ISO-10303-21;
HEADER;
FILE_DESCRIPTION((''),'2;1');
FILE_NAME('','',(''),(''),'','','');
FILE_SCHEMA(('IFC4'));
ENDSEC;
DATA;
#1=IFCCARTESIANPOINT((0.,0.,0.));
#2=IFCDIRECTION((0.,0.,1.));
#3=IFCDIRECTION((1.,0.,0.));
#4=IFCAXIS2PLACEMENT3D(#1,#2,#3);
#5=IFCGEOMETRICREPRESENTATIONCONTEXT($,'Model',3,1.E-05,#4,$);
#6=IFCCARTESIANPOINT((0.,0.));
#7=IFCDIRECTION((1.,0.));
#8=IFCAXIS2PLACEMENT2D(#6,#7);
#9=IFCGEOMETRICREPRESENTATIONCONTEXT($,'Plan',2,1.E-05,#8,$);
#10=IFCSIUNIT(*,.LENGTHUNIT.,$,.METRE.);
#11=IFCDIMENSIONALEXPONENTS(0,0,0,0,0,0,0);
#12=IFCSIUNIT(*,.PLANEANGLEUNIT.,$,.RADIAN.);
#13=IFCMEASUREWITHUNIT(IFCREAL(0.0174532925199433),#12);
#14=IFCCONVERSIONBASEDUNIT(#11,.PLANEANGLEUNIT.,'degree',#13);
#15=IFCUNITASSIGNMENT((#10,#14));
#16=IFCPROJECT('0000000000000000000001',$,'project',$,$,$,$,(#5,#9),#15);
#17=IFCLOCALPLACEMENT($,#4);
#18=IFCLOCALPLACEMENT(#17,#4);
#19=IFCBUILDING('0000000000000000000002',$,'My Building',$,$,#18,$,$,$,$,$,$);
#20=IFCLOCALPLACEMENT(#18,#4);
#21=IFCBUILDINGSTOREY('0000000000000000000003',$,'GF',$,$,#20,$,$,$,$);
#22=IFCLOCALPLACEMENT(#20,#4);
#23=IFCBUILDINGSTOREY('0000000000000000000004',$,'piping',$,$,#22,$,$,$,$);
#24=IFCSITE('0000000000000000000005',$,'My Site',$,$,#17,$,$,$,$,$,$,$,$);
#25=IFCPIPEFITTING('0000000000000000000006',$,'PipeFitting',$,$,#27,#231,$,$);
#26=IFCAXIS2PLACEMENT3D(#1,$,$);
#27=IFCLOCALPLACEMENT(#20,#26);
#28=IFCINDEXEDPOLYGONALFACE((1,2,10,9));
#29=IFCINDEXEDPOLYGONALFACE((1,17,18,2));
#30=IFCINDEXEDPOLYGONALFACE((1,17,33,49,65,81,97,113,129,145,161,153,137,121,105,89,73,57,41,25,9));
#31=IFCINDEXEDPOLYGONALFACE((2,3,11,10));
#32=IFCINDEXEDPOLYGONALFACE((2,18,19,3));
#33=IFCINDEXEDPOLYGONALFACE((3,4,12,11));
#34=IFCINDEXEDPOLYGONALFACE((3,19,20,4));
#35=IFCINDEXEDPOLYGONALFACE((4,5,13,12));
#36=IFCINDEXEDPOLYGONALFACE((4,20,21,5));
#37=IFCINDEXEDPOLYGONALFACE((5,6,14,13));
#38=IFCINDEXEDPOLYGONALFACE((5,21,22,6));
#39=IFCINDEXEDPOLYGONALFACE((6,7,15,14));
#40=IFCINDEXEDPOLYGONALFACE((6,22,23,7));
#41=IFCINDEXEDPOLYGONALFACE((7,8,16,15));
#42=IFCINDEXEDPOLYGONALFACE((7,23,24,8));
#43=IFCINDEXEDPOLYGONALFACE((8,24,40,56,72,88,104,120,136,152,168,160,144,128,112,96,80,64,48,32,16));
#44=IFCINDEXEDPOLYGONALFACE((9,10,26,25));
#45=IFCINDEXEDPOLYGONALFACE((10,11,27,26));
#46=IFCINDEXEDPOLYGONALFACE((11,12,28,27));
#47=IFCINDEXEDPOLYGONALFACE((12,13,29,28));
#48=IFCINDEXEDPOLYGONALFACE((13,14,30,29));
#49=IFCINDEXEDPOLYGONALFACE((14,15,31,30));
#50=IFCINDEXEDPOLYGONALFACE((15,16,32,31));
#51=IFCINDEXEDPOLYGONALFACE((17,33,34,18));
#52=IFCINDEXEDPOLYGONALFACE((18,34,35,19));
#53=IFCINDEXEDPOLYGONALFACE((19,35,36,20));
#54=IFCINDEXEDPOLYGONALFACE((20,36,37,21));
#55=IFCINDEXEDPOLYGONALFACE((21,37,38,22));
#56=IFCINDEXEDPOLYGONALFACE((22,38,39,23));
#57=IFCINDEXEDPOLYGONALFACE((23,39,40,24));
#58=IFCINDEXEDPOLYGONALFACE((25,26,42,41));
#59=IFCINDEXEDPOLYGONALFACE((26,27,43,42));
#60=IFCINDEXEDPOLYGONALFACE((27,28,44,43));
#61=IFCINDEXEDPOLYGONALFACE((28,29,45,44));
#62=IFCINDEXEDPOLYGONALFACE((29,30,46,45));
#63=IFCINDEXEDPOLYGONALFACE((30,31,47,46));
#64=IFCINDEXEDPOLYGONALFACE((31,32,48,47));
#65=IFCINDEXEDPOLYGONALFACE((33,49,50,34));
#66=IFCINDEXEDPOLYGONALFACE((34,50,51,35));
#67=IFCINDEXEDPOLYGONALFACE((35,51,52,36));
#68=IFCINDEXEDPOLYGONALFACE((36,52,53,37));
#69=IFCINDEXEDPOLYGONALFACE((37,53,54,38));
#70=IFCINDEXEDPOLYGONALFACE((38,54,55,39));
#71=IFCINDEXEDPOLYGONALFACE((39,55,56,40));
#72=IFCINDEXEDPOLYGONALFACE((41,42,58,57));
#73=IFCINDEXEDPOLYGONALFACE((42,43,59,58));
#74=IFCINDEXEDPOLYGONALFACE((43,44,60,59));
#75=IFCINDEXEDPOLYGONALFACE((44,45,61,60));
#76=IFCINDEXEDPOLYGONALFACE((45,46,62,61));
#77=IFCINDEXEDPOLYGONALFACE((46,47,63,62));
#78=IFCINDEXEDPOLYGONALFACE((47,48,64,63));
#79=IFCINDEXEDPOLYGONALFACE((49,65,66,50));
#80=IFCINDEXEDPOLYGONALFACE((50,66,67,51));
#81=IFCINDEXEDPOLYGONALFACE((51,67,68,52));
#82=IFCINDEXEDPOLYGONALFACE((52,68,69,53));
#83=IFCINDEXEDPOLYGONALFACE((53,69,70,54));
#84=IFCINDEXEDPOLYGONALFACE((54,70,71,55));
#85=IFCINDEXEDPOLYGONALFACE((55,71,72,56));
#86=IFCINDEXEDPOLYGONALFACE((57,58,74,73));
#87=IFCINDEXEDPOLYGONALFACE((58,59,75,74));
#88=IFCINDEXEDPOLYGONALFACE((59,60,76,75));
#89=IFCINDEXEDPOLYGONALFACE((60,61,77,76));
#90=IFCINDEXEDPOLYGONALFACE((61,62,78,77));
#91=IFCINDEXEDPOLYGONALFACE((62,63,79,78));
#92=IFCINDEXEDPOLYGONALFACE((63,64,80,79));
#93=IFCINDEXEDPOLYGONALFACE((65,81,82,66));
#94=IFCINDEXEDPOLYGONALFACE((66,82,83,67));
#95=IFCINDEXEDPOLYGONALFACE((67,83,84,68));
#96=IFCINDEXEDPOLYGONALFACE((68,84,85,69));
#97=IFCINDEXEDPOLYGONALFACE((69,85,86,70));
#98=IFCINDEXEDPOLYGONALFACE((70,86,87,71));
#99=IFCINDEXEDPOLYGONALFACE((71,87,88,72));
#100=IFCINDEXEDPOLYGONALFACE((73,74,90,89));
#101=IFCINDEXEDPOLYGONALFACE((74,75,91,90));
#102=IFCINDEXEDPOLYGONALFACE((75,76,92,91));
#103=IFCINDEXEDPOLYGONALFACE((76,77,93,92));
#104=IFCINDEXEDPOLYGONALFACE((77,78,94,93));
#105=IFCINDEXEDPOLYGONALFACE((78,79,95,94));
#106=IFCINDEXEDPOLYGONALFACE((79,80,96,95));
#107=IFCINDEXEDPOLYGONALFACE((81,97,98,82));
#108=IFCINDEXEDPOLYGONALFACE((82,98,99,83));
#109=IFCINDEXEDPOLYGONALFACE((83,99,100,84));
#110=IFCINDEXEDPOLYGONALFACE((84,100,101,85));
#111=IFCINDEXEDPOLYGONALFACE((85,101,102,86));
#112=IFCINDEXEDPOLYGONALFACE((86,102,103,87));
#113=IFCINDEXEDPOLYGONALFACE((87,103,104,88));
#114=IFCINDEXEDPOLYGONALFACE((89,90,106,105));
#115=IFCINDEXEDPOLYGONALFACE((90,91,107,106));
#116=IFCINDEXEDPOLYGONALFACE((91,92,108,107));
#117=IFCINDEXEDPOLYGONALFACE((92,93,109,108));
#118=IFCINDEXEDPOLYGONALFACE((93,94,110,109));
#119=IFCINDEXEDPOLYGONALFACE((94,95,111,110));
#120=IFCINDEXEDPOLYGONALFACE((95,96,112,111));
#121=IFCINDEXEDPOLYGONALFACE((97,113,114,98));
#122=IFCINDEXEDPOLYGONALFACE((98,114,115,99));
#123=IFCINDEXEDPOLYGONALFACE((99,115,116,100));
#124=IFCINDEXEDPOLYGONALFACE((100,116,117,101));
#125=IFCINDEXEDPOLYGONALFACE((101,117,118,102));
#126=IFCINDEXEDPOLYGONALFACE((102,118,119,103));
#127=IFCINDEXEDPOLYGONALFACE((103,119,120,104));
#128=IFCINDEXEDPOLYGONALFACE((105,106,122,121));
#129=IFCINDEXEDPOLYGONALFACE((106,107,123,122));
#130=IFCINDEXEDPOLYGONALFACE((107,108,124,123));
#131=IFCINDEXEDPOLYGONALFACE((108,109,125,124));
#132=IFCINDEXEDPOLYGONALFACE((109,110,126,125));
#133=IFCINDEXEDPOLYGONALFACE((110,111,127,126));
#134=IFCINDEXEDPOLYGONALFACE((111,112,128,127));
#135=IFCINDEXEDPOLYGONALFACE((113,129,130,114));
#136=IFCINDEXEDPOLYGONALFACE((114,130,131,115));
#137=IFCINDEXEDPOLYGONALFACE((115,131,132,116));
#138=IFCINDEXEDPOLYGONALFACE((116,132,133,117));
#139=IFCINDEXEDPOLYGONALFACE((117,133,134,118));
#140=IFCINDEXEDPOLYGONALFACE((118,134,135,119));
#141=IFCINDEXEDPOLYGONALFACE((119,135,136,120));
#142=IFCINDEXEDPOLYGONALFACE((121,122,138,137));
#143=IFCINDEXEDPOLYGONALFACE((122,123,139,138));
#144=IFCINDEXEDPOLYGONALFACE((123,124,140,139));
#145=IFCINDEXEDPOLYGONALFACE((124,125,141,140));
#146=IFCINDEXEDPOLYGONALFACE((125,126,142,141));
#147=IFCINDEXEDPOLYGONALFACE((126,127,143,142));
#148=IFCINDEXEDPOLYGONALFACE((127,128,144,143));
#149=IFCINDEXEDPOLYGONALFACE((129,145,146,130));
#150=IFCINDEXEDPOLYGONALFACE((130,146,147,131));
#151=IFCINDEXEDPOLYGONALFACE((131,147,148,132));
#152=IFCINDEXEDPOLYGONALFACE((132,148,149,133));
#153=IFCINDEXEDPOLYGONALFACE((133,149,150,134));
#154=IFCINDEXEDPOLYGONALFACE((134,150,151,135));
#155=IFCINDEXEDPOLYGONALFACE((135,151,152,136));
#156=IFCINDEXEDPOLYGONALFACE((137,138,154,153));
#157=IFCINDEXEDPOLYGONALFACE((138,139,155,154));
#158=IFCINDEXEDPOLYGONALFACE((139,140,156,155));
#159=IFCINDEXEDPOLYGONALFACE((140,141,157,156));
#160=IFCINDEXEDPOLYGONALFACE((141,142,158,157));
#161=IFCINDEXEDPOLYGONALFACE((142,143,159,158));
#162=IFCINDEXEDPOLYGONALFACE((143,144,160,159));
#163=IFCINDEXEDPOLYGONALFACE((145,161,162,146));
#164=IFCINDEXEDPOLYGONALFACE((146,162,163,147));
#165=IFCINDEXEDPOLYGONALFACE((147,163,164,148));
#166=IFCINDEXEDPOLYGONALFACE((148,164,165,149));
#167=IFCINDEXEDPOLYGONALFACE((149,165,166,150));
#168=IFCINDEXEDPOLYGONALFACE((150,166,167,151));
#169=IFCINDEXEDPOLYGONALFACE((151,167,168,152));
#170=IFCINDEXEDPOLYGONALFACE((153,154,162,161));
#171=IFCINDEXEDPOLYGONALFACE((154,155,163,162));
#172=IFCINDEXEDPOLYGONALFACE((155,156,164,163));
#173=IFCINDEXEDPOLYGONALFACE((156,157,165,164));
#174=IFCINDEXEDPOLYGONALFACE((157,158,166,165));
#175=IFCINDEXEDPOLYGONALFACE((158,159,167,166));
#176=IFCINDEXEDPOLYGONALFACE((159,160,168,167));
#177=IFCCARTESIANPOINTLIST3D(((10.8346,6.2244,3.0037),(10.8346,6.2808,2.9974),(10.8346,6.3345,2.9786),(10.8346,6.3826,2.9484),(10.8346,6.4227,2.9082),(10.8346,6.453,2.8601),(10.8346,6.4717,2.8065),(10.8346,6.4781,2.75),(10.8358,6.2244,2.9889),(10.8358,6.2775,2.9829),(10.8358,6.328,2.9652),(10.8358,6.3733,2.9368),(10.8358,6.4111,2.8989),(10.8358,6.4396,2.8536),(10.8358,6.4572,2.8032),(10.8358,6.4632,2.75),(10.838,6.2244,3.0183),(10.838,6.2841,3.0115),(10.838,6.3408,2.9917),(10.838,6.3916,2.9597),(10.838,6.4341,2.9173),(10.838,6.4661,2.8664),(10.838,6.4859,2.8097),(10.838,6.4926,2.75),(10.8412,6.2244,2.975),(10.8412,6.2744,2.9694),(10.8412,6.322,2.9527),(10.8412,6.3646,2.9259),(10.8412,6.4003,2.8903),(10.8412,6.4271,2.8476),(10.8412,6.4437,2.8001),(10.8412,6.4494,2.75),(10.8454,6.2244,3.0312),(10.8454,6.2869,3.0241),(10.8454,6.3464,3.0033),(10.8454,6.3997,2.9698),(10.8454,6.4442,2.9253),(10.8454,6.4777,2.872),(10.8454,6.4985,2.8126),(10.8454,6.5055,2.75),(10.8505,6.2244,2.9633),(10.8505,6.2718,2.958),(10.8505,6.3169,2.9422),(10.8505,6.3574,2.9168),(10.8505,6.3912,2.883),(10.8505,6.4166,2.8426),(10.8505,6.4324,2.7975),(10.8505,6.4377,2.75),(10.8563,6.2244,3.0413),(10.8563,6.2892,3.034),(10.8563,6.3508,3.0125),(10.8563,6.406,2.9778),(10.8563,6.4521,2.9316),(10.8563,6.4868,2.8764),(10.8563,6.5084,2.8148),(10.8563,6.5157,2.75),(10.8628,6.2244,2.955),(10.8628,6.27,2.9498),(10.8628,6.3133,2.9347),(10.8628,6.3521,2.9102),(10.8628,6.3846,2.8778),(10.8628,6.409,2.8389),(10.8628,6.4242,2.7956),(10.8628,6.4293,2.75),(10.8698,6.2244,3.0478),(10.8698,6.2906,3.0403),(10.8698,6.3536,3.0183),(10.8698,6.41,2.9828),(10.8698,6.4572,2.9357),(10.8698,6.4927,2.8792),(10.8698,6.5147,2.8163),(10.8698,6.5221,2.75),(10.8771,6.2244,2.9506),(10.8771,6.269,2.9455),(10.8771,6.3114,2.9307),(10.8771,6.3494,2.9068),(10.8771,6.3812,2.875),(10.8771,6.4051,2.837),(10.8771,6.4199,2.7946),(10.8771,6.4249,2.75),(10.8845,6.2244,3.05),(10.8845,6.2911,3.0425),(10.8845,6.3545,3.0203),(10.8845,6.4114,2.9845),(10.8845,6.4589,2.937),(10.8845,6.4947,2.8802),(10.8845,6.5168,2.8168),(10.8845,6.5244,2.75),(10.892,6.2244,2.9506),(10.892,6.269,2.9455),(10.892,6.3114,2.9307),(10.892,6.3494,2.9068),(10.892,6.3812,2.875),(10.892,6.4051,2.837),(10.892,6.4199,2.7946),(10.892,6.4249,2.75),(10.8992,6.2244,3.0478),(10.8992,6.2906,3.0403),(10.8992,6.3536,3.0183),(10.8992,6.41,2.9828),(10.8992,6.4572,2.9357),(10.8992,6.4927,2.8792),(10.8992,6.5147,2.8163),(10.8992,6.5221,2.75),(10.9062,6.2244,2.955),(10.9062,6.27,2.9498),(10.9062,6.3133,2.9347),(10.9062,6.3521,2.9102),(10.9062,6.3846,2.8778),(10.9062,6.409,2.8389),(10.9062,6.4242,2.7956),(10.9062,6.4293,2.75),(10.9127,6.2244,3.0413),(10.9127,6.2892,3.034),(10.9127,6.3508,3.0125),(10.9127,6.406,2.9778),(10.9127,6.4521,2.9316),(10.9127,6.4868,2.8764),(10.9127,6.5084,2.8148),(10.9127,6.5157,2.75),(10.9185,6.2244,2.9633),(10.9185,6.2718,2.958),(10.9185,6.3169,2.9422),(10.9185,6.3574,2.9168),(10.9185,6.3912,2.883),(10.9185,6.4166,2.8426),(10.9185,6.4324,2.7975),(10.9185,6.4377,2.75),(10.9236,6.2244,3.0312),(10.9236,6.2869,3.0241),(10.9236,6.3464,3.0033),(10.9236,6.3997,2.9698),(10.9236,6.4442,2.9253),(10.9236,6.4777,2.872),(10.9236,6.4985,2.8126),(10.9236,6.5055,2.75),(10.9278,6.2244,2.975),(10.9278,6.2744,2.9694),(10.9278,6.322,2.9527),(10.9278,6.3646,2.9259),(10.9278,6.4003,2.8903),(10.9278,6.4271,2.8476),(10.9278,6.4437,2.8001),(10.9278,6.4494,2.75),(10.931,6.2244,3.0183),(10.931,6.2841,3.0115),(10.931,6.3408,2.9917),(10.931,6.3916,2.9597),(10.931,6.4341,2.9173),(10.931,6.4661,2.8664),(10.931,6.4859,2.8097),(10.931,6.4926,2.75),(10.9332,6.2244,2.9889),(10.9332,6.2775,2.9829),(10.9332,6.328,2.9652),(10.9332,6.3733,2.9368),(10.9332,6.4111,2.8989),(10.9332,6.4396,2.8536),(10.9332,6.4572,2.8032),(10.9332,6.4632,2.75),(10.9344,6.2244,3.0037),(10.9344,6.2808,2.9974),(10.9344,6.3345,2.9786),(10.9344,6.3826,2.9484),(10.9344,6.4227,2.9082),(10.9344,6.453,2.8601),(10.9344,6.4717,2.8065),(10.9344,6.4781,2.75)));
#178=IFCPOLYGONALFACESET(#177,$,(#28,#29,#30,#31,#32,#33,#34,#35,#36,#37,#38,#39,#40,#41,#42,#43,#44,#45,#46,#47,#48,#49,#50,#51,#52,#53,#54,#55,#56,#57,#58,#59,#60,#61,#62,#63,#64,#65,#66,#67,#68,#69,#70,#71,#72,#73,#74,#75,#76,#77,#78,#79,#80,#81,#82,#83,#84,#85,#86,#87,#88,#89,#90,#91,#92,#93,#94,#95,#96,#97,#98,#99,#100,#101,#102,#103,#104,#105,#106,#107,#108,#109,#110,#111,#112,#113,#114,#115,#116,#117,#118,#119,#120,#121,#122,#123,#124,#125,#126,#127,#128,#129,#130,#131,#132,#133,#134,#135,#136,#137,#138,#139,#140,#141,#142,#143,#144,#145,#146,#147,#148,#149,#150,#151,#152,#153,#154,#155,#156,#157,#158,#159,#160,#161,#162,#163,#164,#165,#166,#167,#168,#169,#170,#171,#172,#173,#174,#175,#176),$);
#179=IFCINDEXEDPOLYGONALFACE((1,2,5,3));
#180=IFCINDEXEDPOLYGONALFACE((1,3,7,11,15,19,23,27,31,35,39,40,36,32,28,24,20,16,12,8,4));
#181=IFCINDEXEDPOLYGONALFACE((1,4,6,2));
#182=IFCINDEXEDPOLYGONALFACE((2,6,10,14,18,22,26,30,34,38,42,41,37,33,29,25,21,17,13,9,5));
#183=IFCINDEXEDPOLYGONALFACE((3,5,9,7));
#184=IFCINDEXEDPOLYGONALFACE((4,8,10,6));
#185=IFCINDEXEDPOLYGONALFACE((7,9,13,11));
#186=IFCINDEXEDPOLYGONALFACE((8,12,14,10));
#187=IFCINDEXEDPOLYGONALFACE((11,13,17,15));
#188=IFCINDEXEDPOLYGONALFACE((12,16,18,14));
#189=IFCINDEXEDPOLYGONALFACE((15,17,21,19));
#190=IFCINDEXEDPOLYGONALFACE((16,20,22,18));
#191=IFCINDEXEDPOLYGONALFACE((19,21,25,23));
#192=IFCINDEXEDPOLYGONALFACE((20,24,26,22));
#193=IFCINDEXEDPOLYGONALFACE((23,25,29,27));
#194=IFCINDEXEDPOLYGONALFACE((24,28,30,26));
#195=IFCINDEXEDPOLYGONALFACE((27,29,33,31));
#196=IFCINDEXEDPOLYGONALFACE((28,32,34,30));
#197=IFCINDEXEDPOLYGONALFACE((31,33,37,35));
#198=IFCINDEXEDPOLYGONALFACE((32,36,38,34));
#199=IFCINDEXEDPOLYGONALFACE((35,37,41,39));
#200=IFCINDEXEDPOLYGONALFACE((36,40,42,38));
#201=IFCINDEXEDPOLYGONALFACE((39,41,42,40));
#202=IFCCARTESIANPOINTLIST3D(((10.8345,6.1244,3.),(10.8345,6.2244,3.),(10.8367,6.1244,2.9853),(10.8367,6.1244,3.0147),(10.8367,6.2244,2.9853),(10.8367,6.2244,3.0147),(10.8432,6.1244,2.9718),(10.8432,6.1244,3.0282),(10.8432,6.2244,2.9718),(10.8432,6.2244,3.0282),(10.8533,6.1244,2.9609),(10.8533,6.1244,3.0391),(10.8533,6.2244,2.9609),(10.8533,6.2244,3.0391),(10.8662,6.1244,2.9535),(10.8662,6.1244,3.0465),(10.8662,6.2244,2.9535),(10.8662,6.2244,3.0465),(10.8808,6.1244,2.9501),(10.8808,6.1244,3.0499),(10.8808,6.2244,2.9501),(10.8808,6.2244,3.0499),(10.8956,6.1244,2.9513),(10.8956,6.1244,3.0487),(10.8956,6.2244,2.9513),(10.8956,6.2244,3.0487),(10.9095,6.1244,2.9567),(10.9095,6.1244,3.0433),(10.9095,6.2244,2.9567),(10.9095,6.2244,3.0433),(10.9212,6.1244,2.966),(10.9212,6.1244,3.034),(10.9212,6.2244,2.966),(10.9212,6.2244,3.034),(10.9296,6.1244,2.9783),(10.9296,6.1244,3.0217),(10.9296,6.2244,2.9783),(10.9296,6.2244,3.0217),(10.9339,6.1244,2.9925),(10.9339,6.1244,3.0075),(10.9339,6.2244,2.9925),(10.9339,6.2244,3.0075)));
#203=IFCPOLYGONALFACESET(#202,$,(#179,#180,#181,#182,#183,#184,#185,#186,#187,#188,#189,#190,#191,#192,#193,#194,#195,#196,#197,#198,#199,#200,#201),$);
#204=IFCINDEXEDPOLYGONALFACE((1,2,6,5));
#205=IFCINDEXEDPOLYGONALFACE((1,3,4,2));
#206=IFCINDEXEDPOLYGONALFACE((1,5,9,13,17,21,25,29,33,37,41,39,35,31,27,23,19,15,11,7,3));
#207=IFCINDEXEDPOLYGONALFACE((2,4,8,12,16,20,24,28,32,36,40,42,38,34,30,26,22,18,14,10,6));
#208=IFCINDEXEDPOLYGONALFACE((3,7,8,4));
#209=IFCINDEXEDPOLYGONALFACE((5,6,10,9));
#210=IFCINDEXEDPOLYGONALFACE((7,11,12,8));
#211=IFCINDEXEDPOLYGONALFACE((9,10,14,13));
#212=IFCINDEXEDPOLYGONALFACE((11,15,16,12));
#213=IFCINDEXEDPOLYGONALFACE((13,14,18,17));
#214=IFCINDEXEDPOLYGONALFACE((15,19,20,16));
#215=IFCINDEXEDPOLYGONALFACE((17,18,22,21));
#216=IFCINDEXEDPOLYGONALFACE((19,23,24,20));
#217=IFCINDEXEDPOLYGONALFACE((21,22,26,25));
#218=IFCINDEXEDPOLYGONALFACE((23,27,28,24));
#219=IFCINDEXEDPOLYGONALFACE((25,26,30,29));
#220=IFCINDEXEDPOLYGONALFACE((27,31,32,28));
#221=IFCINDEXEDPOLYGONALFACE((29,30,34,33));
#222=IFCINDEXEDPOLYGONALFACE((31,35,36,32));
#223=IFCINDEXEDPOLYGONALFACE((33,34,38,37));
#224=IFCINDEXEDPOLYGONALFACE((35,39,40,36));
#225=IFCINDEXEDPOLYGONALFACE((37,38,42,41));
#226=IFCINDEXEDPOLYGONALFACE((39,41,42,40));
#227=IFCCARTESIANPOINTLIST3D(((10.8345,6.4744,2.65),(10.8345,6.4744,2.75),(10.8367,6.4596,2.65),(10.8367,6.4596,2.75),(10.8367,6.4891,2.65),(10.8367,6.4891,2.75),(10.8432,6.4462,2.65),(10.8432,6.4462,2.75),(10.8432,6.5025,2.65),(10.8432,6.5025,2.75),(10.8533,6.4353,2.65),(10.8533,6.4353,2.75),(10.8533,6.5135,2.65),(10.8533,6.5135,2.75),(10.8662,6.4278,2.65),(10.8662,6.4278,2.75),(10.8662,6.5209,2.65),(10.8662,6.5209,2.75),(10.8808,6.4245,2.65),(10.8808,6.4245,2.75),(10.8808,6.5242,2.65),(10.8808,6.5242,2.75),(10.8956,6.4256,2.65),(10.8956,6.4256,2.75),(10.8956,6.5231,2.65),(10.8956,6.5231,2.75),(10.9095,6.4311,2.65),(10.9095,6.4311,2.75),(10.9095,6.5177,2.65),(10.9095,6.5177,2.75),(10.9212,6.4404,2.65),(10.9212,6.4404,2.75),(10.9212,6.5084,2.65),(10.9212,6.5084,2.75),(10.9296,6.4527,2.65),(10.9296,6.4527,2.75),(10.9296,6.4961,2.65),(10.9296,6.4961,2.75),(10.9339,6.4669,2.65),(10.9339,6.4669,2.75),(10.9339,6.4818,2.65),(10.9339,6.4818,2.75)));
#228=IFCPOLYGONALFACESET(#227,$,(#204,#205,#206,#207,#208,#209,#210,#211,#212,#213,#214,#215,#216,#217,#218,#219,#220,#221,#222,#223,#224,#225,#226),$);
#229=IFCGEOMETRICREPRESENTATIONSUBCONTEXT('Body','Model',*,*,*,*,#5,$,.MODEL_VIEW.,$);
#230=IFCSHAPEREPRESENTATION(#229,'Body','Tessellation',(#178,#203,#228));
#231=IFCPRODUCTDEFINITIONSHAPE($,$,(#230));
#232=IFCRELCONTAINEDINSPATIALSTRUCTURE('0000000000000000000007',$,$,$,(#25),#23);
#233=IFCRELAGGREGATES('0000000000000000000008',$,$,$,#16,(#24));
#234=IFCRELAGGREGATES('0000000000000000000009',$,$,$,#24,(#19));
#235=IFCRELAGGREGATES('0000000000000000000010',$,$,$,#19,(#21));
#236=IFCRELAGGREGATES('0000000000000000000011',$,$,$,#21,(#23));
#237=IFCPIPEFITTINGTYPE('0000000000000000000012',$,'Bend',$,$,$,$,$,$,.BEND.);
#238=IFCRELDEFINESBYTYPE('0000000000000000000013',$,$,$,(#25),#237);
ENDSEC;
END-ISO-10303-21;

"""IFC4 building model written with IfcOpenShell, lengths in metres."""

from ifc_helpers import new_model, entity, si_unit, converted_unit, frame, origin_with_axes, origin_2d_with_axis, place, context, subcontext, project, spatial, circle, extrude, source, transform, mapped, type_object, type_shapes, element, save


model = new_model("IFC4")

# Units and contexts
model_context = context("Model", 3, precision=1e-05, world=origin_with_axes())
plan_context = context("Plan", 2, precision=1e-05, world=origin_2d_with_axis())
body_context = subcontext(model_context, "Body", "Model", "MODEL_VIEW")
ifc_project = project(units=[si_unit("LENGTHUNIT", "METRE"), converted_unit("PLANEANGLEUNIT", "degree", entity("IfcReal", 0.0174532925199433), si_unit("PLANEANGLEUNIT", "RADIAN"), dimensions=[0, 0, 0, 0, 0, 0, 0])], contexts=[model_context, plan_context])

# Site, building, storeys
site_placement = place(None, origin_with_axes())
site = spatial("IfcSite", under=ifc_project, at=site_placement, Name="My Site")
building_placement = place(site_placement, origin_with_axes())
building = spatial("IfcBuilding", under=site, at=building_placement, Name="My Building")
storey_1_placement = place(building_placement, origin_with_axes())
storey_1 = spatial("IfcBuildingStorey", under=building, at=storey_1_placement, Name="GF")
storey_2_placement = place(storey_1_placement, origin_with_axes())
storey_2 = spatial("IfcBuildingStorey", under=storey_1, at=storey_2_placement, Name="piping")

# Pipe fitting
pipe_fitting_type = type_object("IfcPipeFittingType", Name="Bend", PredefinedType="BEND")
shared_shape = source(origin_with_axes(), body_context, "Body", "SolidModel", [
    entity("IfcSweptDiskSolid", entity("IfcIndexedPolyCurve", entity("IfcCartesianPointList3D", [[0.0, 0.0, 0.1], [0.0, -0.0732, 0.2768], [0.0, -0.25, 0.35]]), [entity("IfcArcIndex", [1, 2, 3])]), 0.05),
    extrude(circle(Radius=0.05), origin_with_axes(), (0.0, 0.0, 1.0), 0.1),
    extrude(circle(Radius=0.05), frame((0.0, -0.25, 0.35), z_axis=(0.0, -1.0, 0.0), x_axis=(1.0, 0.0, 0.0)), (0.0, 0.0, 1.0), 0.1),
])
type_shapes(pipe_fitting_type, [shared_shape])
for number, where, z_axis, x_axis, name in (
    (1, (10.8845, 6.1244, 3.0), (0.0, 1.0, 0.0), (-1.0, 0.0, 0.0), "PipeFitting"),
):
    element("IfcPipeFitting", number, at=place(storey_2_placement, frame(where, z_axis=z_axis, x_axis=x_axis)), inside=storey_2, type_object=pipe_fitting_type, Name=name, context=body_context, shape_type="MappedRepresentation", body=[
        mapped(shared_shape, transform((0.0, 0.0, 0.0), x_axis=(1.0, 0.0, 0.0), y_axis=(0.0, 1.0, 0.0), z_axis=(0.0, 0.0, 1.0), scale=1.0)),
    ])

save(model, "model.ifc")
